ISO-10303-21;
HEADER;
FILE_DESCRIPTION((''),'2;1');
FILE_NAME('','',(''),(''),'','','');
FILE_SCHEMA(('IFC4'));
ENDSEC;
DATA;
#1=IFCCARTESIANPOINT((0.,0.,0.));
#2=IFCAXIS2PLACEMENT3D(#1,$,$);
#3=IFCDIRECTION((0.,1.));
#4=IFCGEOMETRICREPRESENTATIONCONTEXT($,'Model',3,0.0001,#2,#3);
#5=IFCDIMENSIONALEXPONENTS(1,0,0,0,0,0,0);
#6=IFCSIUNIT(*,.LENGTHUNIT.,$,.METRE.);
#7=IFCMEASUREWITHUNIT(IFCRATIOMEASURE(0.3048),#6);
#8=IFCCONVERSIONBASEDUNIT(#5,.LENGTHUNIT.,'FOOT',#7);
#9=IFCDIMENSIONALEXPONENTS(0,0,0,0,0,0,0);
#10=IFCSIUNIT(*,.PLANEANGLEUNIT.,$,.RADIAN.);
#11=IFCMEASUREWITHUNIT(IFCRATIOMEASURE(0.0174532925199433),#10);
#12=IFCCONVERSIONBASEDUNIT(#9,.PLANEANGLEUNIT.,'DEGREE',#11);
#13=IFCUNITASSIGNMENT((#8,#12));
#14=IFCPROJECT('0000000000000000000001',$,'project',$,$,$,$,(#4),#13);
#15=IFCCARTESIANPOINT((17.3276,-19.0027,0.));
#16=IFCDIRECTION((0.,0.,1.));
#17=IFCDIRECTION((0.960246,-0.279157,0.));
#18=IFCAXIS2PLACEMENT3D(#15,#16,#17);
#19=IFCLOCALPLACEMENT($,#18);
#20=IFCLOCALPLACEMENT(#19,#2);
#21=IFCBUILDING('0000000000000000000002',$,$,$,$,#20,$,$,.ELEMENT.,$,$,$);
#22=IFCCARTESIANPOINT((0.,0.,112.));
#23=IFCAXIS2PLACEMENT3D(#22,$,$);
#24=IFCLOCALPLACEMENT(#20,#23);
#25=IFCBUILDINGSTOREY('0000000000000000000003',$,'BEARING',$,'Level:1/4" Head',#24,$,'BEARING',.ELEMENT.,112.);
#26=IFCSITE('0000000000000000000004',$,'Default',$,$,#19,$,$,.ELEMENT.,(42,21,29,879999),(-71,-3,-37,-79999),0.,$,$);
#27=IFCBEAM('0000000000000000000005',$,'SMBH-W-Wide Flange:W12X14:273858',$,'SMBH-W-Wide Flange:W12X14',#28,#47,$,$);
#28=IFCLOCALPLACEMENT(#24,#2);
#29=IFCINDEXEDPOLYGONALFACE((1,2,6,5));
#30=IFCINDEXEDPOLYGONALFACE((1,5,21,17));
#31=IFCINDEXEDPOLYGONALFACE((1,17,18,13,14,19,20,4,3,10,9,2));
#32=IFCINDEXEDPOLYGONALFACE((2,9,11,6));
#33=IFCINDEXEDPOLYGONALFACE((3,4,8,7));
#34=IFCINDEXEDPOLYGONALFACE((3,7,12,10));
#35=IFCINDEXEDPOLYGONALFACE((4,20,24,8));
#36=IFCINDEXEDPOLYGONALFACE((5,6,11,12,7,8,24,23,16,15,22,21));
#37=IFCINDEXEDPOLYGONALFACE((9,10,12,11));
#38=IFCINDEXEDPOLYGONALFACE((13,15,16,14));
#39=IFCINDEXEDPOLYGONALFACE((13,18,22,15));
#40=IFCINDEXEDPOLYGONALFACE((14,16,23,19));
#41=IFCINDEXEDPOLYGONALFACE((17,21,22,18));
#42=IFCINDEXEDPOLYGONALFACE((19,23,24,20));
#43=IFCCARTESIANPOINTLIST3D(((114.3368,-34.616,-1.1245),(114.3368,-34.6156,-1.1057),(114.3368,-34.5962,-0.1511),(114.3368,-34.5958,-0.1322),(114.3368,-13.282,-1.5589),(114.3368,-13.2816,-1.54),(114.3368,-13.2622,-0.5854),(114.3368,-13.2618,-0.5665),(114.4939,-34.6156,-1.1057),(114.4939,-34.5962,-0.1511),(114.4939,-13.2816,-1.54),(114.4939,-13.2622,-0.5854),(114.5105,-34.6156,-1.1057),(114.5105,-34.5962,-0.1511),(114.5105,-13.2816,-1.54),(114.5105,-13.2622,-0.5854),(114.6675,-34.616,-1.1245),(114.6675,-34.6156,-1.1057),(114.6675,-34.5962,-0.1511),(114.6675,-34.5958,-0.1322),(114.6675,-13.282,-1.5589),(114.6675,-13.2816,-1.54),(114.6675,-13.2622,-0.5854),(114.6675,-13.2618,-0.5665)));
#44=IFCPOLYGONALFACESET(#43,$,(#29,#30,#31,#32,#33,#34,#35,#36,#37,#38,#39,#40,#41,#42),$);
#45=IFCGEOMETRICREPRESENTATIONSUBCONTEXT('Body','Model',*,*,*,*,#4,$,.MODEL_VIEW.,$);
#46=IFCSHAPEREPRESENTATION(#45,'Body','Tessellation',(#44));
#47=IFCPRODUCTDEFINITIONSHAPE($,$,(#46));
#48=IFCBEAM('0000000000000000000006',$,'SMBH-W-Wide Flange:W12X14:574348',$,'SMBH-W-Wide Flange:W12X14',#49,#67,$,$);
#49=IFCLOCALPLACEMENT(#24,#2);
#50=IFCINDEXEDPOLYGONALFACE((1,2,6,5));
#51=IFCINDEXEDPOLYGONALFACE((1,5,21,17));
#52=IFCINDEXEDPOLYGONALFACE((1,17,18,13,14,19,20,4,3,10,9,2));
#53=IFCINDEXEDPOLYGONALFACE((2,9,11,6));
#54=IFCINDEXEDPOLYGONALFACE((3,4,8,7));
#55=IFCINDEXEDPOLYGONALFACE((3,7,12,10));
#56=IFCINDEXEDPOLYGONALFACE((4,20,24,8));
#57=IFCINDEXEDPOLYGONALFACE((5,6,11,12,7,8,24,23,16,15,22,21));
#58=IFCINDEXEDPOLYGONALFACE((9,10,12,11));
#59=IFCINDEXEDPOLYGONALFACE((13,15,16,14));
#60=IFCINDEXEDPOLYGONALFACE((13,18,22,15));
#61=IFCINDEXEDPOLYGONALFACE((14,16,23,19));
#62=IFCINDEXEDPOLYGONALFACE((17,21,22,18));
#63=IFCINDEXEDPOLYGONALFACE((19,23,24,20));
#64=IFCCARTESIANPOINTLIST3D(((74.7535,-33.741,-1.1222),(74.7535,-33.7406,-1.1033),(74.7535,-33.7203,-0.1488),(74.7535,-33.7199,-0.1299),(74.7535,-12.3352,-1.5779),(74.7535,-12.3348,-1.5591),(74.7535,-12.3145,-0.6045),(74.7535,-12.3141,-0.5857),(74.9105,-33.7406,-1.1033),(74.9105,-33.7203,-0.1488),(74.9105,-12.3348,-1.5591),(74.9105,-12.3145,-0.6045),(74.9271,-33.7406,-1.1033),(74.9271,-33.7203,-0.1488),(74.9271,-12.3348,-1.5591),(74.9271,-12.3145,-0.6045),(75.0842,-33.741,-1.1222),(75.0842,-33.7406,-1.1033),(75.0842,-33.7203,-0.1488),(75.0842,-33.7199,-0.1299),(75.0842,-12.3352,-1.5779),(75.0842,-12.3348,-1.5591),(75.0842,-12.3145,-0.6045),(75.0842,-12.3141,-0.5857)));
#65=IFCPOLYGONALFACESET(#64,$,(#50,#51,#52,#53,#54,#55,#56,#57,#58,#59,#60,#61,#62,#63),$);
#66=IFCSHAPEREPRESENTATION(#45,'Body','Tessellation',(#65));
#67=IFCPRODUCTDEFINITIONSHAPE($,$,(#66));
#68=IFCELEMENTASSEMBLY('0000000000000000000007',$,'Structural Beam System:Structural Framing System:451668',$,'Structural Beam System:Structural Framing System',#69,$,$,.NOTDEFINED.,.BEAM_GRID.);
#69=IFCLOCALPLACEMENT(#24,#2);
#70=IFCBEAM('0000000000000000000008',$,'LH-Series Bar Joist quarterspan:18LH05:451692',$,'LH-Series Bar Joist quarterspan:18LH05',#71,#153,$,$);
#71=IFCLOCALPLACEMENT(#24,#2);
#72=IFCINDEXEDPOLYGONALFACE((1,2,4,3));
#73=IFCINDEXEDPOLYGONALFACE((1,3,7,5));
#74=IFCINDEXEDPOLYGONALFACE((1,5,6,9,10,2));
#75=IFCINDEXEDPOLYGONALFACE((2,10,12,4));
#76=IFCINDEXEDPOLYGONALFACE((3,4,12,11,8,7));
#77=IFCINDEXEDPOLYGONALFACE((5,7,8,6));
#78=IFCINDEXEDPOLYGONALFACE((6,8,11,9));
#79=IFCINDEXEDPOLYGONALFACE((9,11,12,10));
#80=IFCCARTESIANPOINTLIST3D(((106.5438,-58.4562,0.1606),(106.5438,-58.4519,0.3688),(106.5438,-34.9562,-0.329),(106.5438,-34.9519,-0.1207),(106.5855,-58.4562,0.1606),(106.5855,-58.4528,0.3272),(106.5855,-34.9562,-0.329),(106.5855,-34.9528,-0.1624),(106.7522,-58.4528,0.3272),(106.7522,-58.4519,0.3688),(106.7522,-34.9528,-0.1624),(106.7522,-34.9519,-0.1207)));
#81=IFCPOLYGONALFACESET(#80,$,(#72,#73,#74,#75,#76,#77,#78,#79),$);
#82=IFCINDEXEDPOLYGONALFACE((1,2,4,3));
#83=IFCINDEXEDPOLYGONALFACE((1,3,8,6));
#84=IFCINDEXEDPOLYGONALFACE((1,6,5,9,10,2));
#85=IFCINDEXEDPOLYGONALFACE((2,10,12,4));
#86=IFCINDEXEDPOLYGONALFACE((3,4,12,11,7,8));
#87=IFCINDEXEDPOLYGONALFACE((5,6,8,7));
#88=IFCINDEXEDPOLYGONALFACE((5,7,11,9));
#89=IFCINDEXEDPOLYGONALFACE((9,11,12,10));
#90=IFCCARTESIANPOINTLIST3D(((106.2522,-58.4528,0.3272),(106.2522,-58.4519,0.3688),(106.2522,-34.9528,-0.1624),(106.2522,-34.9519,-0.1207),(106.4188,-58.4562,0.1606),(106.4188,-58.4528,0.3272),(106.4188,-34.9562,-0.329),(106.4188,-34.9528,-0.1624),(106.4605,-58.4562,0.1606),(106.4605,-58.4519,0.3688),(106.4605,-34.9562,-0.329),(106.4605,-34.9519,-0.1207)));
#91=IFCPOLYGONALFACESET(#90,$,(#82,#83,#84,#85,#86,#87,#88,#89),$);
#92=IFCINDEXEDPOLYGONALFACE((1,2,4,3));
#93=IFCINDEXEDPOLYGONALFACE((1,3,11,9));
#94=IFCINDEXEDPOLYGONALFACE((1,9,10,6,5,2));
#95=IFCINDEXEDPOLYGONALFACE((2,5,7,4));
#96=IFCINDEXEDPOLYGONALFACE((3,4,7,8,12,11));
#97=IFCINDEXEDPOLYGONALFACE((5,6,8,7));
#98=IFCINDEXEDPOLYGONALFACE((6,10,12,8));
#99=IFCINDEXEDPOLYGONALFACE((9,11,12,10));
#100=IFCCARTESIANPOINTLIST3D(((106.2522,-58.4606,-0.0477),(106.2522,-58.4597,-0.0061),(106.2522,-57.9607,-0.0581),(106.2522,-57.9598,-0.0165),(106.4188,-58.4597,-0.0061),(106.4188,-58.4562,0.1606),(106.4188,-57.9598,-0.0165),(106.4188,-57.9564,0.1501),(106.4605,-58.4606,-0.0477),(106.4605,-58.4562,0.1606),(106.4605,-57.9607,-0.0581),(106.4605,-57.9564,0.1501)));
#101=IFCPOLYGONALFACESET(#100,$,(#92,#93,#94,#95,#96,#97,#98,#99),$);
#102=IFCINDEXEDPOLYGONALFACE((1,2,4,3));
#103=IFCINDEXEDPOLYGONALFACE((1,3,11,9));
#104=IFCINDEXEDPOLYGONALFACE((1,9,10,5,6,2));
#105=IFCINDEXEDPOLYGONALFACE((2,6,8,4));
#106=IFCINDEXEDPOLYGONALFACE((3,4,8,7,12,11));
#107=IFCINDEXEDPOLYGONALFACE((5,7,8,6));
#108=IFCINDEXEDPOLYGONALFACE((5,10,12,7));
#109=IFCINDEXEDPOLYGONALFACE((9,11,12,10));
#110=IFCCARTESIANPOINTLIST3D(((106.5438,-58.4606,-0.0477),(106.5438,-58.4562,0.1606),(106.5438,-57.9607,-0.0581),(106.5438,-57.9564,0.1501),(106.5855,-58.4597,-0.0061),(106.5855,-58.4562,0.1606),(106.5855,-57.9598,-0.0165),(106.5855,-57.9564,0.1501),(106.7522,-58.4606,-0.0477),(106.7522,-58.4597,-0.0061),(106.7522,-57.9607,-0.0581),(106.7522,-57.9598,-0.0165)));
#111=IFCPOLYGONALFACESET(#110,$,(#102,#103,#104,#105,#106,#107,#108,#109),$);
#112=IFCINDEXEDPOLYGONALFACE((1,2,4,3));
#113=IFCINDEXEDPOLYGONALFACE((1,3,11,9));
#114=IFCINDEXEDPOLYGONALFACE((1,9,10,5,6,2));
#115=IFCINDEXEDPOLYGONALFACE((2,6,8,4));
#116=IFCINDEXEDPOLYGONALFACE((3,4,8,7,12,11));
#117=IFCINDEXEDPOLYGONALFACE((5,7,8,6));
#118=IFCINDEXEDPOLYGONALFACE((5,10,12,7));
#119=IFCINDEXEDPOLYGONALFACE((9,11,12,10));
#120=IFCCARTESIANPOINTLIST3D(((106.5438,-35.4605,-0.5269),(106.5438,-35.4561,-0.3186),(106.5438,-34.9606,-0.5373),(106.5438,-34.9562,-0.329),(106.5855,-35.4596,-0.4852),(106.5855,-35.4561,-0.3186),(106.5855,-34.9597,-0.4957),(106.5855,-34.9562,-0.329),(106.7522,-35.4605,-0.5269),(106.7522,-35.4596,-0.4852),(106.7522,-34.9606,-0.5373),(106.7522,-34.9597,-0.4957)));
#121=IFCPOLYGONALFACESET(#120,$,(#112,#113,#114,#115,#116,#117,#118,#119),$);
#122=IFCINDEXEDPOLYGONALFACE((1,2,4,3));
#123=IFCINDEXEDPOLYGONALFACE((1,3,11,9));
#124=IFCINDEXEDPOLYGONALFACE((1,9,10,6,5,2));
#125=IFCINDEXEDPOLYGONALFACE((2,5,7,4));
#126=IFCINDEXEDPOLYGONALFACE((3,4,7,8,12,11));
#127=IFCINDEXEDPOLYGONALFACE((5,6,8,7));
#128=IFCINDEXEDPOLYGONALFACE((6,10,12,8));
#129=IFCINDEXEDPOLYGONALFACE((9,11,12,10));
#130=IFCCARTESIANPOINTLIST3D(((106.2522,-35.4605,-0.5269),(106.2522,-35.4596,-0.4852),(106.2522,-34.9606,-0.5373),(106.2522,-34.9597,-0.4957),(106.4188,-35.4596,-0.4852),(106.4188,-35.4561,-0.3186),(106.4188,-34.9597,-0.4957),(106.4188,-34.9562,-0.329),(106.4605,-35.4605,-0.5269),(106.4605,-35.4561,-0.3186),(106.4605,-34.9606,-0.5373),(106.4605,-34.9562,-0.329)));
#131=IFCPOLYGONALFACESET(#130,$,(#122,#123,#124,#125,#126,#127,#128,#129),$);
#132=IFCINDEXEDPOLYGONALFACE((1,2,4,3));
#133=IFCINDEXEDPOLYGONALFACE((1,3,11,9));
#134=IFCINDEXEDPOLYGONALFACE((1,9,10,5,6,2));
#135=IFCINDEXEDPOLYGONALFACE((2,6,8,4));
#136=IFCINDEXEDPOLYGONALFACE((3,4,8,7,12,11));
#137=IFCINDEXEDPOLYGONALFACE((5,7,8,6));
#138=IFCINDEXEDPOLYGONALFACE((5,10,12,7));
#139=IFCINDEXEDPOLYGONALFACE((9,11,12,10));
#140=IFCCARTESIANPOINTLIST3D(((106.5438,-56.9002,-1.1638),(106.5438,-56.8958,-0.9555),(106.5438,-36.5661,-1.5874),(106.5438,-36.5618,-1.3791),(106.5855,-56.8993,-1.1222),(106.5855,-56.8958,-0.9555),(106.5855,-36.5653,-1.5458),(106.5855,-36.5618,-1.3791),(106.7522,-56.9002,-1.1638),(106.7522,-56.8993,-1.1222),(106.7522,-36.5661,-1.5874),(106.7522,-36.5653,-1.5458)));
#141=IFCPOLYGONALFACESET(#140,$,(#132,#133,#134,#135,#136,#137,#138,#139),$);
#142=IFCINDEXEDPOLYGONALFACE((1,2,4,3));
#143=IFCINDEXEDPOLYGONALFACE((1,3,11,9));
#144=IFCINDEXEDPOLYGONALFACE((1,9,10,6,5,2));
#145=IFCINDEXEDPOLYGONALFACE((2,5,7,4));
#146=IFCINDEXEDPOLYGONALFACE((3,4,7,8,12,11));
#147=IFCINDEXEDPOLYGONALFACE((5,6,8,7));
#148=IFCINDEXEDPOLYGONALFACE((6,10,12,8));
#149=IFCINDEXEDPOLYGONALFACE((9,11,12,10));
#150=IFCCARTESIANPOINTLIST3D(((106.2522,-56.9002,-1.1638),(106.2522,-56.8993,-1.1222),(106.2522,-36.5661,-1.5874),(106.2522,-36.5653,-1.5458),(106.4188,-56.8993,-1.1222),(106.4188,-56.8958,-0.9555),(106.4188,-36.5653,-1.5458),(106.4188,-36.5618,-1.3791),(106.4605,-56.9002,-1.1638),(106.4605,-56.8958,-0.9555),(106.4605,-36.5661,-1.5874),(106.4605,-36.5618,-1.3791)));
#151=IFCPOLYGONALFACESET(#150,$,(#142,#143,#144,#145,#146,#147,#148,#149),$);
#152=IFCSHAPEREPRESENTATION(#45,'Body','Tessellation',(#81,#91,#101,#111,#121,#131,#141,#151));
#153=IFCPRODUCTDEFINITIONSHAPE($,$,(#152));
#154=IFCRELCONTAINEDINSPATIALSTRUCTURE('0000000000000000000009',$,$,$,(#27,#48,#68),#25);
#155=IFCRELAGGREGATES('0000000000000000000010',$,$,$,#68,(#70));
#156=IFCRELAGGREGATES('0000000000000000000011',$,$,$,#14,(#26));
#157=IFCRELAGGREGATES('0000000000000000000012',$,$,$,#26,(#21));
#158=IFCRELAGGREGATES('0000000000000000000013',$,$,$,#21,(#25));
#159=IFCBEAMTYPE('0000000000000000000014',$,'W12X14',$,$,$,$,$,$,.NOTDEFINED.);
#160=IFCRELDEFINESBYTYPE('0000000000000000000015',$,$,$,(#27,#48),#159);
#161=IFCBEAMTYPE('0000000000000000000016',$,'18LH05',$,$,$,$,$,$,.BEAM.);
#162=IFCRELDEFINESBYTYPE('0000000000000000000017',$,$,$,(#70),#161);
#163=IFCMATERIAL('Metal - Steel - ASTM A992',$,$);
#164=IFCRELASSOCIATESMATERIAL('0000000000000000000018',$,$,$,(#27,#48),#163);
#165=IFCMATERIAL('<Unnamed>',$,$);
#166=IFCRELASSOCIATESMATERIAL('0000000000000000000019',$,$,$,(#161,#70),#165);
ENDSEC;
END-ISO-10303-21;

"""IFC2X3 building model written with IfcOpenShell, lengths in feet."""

from ifc_helpers import new_model, entity, si_unit, converted_unit, direction, frame, frame_2d, origin, place, context, subcontext, project, spatial, polyline, i_section, outline, extrude, source, transform, mapped, material, type_object, type_shapes, element, aggregate, save


model = new_model("IFC2X3")

# Units and contexts
model_context = context("Model", 3, precision=0.0001, world=origin(), true_north=direction((0.0, 1.0)))
body_context = subcontext(model_context, "Body", "Model", "MODEL_VIEW")
ifc_project = project(units=[converted_unit("LENGTHUNIT", "FOOT", entity("IfcRatioMeasure", 0.3048), si_unit("LENGTHUNIT", "METRE"), dimensions=[1, 0, 0, 0, 0, 0, 0]), converted_unit("PLANEANGLEUNIT", "DEGREE", entity("IfcRatioMeasure", 0.0174532925199433), si_unit("PLANEANGLEUNIT", "RADIAN"), dimensions=[0, 0, 0, 0, 0, 0, 0])], contexts=[model_context])

# Site, building, storey
site_placement = place(None, frame((17.3276, -19.0027, 0.0), z_axis=(0.0, 0.0, 1.0), x_axis=(0.960246, -0.279157, 0.0)))
site = spatial("IfcSite", under=ifc_project, at=site_placement, Name="Default", CompositionType="ELEMENT", RefLatitude=(42, 21, 29, 879999), RefLongitude=(-71, -3, -37, -79999), RefElevation=0.0)
building_placement = place(site_placement, origin())
building = spatial("IfcBuilding", under=site, at=building_placement, CompositionType="ELEMENT")
storey_placement = place(building_placement, frame((0.0, 0.0, 112.0)))
storey = spatial("IfcBuildingStorey", under=building, at=storey_placement, Name="BEARING", ObjectType="Level:1/4\" Head", LongName="BEARING", CompositionType="ELEMENT", Elevation=112.0)

# Beams
ifc_material_1 = material(Name="Metal - Steel - ASTM A992")
beam_type_1 = type_object("IfcBeamType", Name="W12X14", PredefinedType="NOTDEFINED")
beam_1_placement = place(storey_placement, frame((114.5022, -34.9493, 0.0), z_axis=(0.0, 0.020354, 0.999793), x_axis=(0.0, 0.999793, -0.020354)))
element("IfcBeam", 1, at=beam_1_placement, inside=storey, type_object=beam_type_1, material=ifc_material_1, Name="SMBH-W-Wide Flange:W12X14:273858", ObjectType="SMBH-W-Wide Flange:W12X14", context=body_context, shape_type="SweptSolid", body=[
    extrude(i_section(OverallWidth=0.3307, OverallDepth=0.9925, WebThickness=0.0166, FlangeThickness=0.0189, at=frame_2d((0.0, 0.0), x_axis=(0.0, 1.0))), frame((0.3561, 0.0, -0.6213), z_axis=(1.0, 0.0, 0.0), x_axis=(0.0, 0.0, -1.0)), (0.0, 0.0, 1.0), 21.3384),
])
beam_2_placement = place(storey_placement, frame((74.9188, -33.9493, 0.0), z_axis=(0.0, 0.021286, 0.999773), x_axis=(0.0, 0.999773, -0.021286)))
element("IfcBeam", 2, at=beam_2_placement, inside=storey, type_object=beam_type_1, material=ifc_material_1, Name="SMBH-W-Wide Flange:W12X14:574348", ObjectType="SMBH-W-Wide Flange:W12X14", context=body_context, shape_type="SweptSolid", body=[
    extrude(i_section(OverallWidth=0.3307, OverallDepth=0.9925, WebThickness=0.0166, FlangeThickness=0.0189, at=frame_2d((0.0, 0.0), x_axis=(0.0, 1.0))), frame((0.2322, 0.0, -0.6213), z_axis=(1.0, 0.0, 0.0), x_axis=(0.0, 0.0, -1.0)), (0.0, 0.0, 1.0), 21.4107),
])

# Element assembly, beam
assembly_1_placement = place(storey_placement, origin())
assembly_1 = element("IfcElementAssembly", 3, at=assembly_1_placement, inside=storey, Name="Structural Beam System:Structural Framing System:451668", ObjectType="Structural Beam System:Structural Framing System", AssemblyPlace="NOTDEFINED", PredefinedType="BEAM_GRID")
ifc_material_2 = material(Name="<Unnamed>")
beam_type_2 = type_object("IfcBeamType", Name="18LH05", PredefinedType="BEAM", material=ifc_material_2)
shared_shape_1 = source(origin(), body_context, "Body", "SweptSolid", [
    extrude(outline(polyline([(-0.0833, -0.125), (-0.0417, -0.125), (-0.0417, 0.0417), (0.125, 0.0417), (0.125, 0.0833), (-0.0833, 0.0833), (-0.0833, -0.125)])), frame((-11.7525, -0.125, 0.6667), z_axis=(1.0, 0.0, 0.0), x_axis=(0.0, 0.0, -1.0)), (0.0, 0.0, 1.0), 23.5051),
    extrude(outline(polyline([(-0.0833, -0.0833), (0.125, -0.0833), (0.125, -0.0417), (-0.0417, -0.0417), (-0.0417, 0.125), (-0.0833, 0.125), (-0.0833, -0.0833)])), frame((-11.7525, 0.125, 0.6667), z_axis=(1.0, 0.0, 0.0), x_axis=(0.0, 0.0, -1.0)), (0.0, 0.0, 1.0), 23.5051),
    extrude(outline(polyline([(-0.125, -0.0833), (0.0833, -0.0833), (0.0833, 0.125), (0.0417, 0.125), (0.0417, -0.0417), (-0.125, -0.0417), (-0.125, -0.0833)])), frame((-11.7525, 0.125, 0.4167), z_axis=(1.0, 0.0, 0.0), x_axis=(0.0, 0.0, -1.0)), (0.0, 0.0, 1.0), 0.5),
    extrude(outline(polyline([(0.0417, -0.125), (0.0833, -0.125), (0.0833, 0.0833), (-0.125, 0.0833), (-0.125, 0.0417), (0.0417, 0.0417), (0.0417, -0.125)])), frame((-11.7525, -0.125, 0.4167), z_axis=(1.0, 0.0, 0.0), x_axis=(0.0, 0.0, -1.0)), (0.0, 0.0, 1.0), 0.5),
    extrude(outline(polyline([(0.0417, -0.125), (0.0833, -0.125), (0.0833, 0.0833), (-0.125, 0.0833), (-0.125, 0.0417), (0.0417, 0.0417), (0.0417, -0.125)])), frame((11.2525, -0.125, 0.4167), z_axis=(1.0, 0.0, 0.0), x_axis=(0.0, 0.0, -1.0)), (0.0, 0.0, 1.0), 0.5),
    extrude(outline(polyline([(-0.125, -0.0833), (0.0833, -0.0833), (0.0833, 0.125), (0.0417, 0.125), (0.0417, -0.0417), (-0.125, -0.0417), (-0.125, -0.0833)])), frame((11.2525, 0.125, 0.4167), z_axis=(1.0, 0.0, 0.0), x_axis=(0.0, 0.0, -1.0)), (0.0, 0.0, 1.0), 0.5),
    extrude(outline(polyline([(0.0417, -0.125), (0.0833, -0.125), (0.0833, 0.0833), (-0.125, 0.0833), (-0.125, 0.0417), (0.0417, 0.0417), (0.0417, -0.125)])), frame((-10.1692, -0.125, -0.6667), z_axis=(1.0, 0.0, 0.0), x_axis=(0.0, 0.0, -1.0)), (0.0, 0.0, 1.0), 20.3384),
    extrude(outline(polyline([(-0.125, -0.0833), (0.0833, -0.0833), (0.0833, 0.125), (0.0417, 0.125), (0.0417, -0.0417), (-0.125, -0.0417), (-0.125, -0.0833)])), frame((-10.1692, 0.125, -0.6667), z_axis=(1.0, 0.0, 0.0), x_axis=(0.0, 0.0, -1.0)), (0.0, 0.0, 1.0), 20.3384),
])
type_shapes(beam_type_2, [shared_shape_1])
beam_3_placement = place(assembly_1_placement, frame((106.5022, -46.7175, -0.6258), z_axis=(0.0, 0.020829, 0.999783), x_axis=(0.0, 0.999783, -0.020829)))
beam_3 = element("IfcBeam", 4, at=beam_3_placement, type_object=beam_type_2, material=ifc_material_2, Name="LH-Series Bar Joist quarterspan:18LH05:451692", ObjectType="LH-Series Bar Joist quarterspan:18LH05", context=body_context, shape_type="MappedRepresentation", body=[
    mapped(shared_shape_1, transform((0.0, 0.0, 0.0), scale=1.0)),
])
aggregate(assembly_1, [beam_3])

save(model, "model.ifc")
